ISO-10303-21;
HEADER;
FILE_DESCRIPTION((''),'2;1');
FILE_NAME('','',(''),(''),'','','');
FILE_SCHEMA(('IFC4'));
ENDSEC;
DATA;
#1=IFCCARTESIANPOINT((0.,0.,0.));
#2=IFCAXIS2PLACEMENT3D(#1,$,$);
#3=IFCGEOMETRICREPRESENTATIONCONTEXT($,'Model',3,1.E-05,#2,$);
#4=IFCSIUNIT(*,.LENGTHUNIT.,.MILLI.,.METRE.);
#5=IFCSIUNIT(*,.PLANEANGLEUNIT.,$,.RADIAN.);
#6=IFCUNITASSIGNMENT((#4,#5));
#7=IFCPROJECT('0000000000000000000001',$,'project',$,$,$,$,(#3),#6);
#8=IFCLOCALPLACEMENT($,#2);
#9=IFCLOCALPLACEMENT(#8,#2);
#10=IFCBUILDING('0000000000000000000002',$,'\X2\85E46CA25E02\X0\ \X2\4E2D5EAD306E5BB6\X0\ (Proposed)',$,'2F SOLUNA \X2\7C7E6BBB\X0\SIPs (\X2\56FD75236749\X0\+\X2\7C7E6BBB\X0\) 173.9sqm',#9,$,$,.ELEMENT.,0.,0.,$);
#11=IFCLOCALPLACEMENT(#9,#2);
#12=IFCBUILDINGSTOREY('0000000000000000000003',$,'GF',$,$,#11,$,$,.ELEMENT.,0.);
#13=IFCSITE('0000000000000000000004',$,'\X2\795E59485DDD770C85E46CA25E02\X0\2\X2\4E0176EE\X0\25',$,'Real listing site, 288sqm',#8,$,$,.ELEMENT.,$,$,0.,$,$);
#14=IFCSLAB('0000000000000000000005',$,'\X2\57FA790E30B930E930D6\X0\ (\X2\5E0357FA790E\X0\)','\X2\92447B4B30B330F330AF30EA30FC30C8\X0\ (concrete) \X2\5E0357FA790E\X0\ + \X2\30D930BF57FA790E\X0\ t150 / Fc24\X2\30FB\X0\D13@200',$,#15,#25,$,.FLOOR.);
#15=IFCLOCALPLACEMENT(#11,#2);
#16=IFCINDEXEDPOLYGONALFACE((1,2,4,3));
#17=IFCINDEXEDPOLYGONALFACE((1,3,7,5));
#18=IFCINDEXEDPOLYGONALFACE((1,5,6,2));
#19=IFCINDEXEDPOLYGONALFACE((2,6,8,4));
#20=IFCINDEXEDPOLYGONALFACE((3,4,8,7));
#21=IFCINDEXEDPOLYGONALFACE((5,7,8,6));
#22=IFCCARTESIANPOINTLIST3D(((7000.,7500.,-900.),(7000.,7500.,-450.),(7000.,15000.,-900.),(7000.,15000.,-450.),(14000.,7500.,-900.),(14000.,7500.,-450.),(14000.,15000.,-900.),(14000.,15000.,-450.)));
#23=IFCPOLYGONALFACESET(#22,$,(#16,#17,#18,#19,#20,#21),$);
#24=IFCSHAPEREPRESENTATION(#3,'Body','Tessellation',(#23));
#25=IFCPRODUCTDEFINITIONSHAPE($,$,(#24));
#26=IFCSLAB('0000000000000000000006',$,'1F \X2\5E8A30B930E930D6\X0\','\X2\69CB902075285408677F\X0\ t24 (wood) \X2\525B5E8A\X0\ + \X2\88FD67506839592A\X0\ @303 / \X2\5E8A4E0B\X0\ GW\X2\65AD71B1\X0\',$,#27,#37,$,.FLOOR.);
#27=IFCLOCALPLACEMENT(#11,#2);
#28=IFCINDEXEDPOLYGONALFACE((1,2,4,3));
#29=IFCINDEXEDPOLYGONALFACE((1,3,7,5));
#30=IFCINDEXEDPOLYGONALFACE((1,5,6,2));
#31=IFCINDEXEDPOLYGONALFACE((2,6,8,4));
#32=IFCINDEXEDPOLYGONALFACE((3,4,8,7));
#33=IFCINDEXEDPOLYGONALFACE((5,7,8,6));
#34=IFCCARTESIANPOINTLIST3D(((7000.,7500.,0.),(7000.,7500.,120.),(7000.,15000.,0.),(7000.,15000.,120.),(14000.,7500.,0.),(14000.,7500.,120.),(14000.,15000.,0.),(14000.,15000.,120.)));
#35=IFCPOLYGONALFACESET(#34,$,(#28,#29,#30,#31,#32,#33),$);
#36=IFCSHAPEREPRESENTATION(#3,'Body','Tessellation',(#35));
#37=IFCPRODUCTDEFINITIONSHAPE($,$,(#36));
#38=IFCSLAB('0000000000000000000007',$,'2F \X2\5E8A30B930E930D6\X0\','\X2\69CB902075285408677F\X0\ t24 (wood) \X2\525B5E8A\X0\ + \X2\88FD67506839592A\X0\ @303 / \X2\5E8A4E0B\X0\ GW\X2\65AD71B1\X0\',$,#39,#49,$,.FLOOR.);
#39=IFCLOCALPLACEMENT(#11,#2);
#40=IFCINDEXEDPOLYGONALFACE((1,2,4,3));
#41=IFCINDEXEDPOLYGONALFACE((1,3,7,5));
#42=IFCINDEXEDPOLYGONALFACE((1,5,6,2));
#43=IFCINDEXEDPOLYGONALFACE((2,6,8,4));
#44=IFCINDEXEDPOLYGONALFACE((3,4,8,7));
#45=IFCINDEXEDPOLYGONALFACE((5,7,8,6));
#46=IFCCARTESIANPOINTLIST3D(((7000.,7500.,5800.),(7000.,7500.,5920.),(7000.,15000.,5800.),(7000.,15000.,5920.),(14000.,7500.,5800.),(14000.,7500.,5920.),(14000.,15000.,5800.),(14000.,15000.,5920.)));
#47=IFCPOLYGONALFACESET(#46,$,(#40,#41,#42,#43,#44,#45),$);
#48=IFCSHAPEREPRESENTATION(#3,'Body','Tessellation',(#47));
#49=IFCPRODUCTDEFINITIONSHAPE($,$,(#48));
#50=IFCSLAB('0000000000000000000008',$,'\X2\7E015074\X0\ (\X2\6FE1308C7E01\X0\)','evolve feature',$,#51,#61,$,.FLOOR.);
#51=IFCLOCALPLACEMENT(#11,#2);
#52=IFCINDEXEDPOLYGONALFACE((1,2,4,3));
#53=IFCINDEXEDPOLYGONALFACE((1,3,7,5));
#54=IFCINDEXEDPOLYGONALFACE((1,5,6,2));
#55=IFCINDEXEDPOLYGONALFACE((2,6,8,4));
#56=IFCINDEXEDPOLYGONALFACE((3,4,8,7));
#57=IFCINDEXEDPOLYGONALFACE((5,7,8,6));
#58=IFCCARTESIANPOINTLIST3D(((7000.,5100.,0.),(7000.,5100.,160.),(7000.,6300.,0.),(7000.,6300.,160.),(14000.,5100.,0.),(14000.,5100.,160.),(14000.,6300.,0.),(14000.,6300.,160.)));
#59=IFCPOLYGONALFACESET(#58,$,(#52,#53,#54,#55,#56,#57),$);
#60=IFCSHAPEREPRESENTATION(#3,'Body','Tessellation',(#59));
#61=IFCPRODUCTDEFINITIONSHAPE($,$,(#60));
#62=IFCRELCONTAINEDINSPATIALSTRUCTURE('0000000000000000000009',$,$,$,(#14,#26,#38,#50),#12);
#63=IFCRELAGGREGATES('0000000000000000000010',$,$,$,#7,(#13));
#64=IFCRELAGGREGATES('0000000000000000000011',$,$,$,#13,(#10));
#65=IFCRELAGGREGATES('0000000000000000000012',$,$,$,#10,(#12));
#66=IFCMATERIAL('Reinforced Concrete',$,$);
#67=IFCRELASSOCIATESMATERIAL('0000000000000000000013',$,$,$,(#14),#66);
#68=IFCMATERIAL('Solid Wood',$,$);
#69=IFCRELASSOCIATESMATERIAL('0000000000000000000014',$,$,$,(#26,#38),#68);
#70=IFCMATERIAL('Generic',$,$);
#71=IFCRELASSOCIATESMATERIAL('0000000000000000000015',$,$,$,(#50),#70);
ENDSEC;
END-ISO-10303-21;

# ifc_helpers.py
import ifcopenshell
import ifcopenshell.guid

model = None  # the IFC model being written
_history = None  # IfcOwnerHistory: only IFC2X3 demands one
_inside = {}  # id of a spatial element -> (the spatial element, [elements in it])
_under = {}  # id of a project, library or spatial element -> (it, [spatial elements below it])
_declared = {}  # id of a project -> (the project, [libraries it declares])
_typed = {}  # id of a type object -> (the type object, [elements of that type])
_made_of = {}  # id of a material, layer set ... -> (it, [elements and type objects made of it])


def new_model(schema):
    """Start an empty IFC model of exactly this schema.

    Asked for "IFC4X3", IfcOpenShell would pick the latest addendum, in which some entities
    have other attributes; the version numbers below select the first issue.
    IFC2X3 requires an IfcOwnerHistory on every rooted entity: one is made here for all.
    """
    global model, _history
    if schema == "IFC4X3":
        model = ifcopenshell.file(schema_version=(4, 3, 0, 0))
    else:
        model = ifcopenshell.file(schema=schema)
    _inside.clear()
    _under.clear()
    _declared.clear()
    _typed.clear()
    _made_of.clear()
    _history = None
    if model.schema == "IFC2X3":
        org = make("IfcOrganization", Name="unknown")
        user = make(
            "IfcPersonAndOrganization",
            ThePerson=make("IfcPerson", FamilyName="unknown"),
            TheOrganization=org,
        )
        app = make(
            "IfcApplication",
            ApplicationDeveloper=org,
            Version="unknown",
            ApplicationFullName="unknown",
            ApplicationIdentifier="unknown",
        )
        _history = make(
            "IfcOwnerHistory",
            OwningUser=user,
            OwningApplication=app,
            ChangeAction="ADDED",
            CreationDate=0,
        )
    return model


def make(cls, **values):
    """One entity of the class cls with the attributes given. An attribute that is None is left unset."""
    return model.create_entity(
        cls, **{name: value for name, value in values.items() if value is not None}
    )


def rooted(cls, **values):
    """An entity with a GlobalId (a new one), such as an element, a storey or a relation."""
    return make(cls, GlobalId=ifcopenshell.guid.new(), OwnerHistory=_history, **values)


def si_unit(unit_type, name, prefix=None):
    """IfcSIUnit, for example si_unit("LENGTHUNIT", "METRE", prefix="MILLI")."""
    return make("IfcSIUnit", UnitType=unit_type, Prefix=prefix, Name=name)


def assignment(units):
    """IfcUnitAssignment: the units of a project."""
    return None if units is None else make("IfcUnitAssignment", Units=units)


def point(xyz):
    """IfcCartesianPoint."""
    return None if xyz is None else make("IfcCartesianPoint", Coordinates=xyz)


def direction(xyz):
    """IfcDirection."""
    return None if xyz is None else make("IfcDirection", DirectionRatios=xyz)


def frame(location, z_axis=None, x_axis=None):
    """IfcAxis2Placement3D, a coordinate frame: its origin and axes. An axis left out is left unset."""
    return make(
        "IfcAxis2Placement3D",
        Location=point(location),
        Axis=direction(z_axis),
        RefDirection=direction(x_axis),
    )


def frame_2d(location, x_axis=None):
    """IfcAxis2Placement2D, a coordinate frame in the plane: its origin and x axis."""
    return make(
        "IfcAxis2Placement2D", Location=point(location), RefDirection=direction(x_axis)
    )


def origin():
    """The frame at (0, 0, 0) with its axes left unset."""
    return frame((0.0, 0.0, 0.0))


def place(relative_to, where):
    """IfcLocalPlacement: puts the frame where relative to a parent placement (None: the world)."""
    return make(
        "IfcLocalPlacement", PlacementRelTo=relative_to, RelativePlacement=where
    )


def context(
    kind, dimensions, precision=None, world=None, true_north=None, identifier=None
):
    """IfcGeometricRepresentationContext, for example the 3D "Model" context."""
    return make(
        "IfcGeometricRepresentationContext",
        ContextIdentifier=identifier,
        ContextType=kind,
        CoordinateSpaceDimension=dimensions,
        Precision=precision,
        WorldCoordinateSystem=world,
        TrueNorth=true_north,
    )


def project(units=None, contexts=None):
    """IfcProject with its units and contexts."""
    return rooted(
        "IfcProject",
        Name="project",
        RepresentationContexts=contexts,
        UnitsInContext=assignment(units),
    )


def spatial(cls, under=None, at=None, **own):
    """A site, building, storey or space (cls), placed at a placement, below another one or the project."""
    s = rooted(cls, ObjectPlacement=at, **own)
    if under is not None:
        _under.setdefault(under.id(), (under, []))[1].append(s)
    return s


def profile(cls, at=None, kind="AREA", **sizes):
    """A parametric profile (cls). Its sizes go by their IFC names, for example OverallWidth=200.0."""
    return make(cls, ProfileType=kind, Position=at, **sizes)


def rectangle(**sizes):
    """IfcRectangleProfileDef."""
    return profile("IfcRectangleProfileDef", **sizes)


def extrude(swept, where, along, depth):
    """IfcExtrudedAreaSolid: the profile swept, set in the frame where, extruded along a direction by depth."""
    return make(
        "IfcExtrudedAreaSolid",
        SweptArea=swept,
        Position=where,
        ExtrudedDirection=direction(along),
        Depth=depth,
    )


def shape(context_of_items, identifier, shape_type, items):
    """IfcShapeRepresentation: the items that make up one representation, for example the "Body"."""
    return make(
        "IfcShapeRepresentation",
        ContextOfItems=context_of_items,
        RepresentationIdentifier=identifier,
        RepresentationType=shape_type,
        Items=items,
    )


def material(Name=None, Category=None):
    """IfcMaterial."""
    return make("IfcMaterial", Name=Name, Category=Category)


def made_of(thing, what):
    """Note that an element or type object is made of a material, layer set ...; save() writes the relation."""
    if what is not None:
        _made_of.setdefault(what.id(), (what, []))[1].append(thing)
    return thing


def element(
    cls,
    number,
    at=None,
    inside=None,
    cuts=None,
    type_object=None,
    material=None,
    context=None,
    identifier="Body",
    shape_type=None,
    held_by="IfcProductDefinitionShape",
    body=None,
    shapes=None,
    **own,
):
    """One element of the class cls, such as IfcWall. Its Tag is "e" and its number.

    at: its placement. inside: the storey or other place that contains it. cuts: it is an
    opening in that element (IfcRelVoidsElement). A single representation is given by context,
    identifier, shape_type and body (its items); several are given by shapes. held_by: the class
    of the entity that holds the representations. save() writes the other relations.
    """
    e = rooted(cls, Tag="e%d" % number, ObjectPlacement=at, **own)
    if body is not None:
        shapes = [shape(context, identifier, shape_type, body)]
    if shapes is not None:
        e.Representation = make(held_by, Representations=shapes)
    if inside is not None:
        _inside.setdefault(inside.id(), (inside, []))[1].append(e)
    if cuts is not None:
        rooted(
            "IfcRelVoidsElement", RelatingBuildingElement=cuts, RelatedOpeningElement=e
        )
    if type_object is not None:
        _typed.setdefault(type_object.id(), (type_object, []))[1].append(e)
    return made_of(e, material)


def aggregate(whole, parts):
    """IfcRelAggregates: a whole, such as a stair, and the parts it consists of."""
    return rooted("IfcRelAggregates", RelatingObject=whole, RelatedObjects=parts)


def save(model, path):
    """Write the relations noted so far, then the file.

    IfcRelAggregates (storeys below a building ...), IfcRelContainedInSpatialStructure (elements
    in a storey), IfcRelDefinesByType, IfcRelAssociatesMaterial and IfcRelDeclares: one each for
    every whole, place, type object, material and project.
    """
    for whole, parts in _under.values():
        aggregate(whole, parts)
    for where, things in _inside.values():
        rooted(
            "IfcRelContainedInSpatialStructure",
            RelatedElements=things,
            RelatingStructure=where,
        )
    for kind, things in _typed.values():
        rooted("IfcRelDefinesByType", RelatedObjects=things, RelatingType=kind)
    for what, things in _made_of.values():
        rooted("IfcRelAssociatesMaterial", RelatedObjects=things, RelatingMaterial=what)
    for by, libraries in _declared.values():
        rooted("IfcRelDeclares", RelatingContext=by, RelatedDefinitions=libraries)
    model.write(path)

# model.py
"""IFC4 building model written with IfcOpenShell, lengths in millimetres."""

from ifc_helpers import new_model, si_unit, frame, frame_2d, origin, place, context, project, spatial, rectangle, extrude, material, element, save


model = new_model("IFC4")

# Units and contexts
model_context = context("Model", 3, precision=1e-05, world=origin())
ifc_project = project(units=[si_unit("LENGTHUNIT", "METRE", prefix="MILLI"), si_unit("PLANEANGLEUNIT", "RADIAN")], contexts=[model_context])

# Site, building, storey
site_placement = place(None, origin())
site = spatial("IfcSite", under=ifc_project, at=site_placement, Name="神奈川県藤沢市2丁目25", ObjectType="Real listing site, 288sqm", CompositionType="ELEMENT", RefElevation=0.0)
building_placement = place(site_placement, origin())
building = spatial("IfcBuilding", under=site, at=building_placement, Name="藤沢市 中庭の家 (Proposed)", ObjectType="2F SOLUNA 籾殻SIPs (国産杉+籾殻) 173.9sqm", CompositionType="ELEMENT", ElevationOfRefHeight=0.0, ElevationOfTerrain=0.0)
storey_placement = place(building_placement, origin())
storey = spatial("IfcBuildingStorey", under=building, at=storey_placement, Name="GF", CompositionType="ELEMENT", Elevation=0.0)

# Slabs
ifc_material_1 = material(Name="Reinforced Concrete")
slab_1_placement = place(storey_placement, frame((3500.0, 3750.0, -450.0)))
element("IfcSlab", 1, at=slab_1_placement, inside=storey, material=ifc_material_1, Name="基礎スラブ (布基礎)", Description="鉄筋コンクリート (concrete) 布基礎 + ベタ基礎 t150 / Fc24・D13@200", PredefinedType="FLOOR", context=model_context, shape_type="SweptSolid", body=[
    extrude(rectangle(XDim=7000.0, YDim=7500.0, at=frame_2d((3500.0, 3750.0))), frame((3500.0, 3750.0, -450.0)), (0.0, 0.0, 1.0), 450.0),
])
ifc_material_2 = material(Name="Solid Wood")
slab_2_placement = place(storey_placement, frame((3500.0, 3750.0, 0.0)))
element("IfcSlab", 2, at=slab_2_placement, inside=storey, material=ifc_material_2, Name="1F 床スラブ", Description="構造用合板 t24 (wood) 剛床 + 製材根太 @303 / 床下 GW断熱", PredefinedType="FLOOR", context=model_context, shape_type="SweptSolid", body=[
    extrude(rectangle(XDim=7000.0, YDim=7500.0, at=frame_2d((3500.0, 3750.0))), frame((3500.0, 3750.0, 0.0)), (0.0, 0.0, 1.0), 120.0),
])
slab_3_placement = place(storey_placement, frame((3500.0, 3750.0, 2900.0)))
element("IfcSlab", 3, at=slab_3_placement, inside=storey, material=ifc_material_2, Name="2F 床スラブ", Description="構造用合板 t24 (wood) 剛床 + 製材根太 @303 / 床下 GW断熱", PredefinedType="FLOOR", context=model_context, shape_type="SweptSolid", body=[
    extrude(rectangle(XDim=7000.0, YDim=7500.0, at=frame_2d((3500.0, 3750.0))), frame((3500.0, 3750.0, 2900.0)), (0.0, 0.0, 1.0), 120.0),
])
ifc_material_3 = material(Name="Generic")
slab_4_placement = place(storey_placement, frame((3500.0, 2550.0, 0.0)))
element("IfcSlab", 4, at=slab_4_placement, inside=storey, material=ifc_material_3, Name="縁側 (濡れ縁)", Description="evolve feature", PredefinedType="FLOOR", context=model_context, shape_type="SweptSolid", body=[
    extrude(rectangle(XDim=7000.0, YDim=1200.0, at=frame_2d((3500.0, 600.0))), frame((3500.0, 2550.0, 0.0)), (0.0, 0.0, 1.0), 160.0),
])

save(model, "model.ifc")
